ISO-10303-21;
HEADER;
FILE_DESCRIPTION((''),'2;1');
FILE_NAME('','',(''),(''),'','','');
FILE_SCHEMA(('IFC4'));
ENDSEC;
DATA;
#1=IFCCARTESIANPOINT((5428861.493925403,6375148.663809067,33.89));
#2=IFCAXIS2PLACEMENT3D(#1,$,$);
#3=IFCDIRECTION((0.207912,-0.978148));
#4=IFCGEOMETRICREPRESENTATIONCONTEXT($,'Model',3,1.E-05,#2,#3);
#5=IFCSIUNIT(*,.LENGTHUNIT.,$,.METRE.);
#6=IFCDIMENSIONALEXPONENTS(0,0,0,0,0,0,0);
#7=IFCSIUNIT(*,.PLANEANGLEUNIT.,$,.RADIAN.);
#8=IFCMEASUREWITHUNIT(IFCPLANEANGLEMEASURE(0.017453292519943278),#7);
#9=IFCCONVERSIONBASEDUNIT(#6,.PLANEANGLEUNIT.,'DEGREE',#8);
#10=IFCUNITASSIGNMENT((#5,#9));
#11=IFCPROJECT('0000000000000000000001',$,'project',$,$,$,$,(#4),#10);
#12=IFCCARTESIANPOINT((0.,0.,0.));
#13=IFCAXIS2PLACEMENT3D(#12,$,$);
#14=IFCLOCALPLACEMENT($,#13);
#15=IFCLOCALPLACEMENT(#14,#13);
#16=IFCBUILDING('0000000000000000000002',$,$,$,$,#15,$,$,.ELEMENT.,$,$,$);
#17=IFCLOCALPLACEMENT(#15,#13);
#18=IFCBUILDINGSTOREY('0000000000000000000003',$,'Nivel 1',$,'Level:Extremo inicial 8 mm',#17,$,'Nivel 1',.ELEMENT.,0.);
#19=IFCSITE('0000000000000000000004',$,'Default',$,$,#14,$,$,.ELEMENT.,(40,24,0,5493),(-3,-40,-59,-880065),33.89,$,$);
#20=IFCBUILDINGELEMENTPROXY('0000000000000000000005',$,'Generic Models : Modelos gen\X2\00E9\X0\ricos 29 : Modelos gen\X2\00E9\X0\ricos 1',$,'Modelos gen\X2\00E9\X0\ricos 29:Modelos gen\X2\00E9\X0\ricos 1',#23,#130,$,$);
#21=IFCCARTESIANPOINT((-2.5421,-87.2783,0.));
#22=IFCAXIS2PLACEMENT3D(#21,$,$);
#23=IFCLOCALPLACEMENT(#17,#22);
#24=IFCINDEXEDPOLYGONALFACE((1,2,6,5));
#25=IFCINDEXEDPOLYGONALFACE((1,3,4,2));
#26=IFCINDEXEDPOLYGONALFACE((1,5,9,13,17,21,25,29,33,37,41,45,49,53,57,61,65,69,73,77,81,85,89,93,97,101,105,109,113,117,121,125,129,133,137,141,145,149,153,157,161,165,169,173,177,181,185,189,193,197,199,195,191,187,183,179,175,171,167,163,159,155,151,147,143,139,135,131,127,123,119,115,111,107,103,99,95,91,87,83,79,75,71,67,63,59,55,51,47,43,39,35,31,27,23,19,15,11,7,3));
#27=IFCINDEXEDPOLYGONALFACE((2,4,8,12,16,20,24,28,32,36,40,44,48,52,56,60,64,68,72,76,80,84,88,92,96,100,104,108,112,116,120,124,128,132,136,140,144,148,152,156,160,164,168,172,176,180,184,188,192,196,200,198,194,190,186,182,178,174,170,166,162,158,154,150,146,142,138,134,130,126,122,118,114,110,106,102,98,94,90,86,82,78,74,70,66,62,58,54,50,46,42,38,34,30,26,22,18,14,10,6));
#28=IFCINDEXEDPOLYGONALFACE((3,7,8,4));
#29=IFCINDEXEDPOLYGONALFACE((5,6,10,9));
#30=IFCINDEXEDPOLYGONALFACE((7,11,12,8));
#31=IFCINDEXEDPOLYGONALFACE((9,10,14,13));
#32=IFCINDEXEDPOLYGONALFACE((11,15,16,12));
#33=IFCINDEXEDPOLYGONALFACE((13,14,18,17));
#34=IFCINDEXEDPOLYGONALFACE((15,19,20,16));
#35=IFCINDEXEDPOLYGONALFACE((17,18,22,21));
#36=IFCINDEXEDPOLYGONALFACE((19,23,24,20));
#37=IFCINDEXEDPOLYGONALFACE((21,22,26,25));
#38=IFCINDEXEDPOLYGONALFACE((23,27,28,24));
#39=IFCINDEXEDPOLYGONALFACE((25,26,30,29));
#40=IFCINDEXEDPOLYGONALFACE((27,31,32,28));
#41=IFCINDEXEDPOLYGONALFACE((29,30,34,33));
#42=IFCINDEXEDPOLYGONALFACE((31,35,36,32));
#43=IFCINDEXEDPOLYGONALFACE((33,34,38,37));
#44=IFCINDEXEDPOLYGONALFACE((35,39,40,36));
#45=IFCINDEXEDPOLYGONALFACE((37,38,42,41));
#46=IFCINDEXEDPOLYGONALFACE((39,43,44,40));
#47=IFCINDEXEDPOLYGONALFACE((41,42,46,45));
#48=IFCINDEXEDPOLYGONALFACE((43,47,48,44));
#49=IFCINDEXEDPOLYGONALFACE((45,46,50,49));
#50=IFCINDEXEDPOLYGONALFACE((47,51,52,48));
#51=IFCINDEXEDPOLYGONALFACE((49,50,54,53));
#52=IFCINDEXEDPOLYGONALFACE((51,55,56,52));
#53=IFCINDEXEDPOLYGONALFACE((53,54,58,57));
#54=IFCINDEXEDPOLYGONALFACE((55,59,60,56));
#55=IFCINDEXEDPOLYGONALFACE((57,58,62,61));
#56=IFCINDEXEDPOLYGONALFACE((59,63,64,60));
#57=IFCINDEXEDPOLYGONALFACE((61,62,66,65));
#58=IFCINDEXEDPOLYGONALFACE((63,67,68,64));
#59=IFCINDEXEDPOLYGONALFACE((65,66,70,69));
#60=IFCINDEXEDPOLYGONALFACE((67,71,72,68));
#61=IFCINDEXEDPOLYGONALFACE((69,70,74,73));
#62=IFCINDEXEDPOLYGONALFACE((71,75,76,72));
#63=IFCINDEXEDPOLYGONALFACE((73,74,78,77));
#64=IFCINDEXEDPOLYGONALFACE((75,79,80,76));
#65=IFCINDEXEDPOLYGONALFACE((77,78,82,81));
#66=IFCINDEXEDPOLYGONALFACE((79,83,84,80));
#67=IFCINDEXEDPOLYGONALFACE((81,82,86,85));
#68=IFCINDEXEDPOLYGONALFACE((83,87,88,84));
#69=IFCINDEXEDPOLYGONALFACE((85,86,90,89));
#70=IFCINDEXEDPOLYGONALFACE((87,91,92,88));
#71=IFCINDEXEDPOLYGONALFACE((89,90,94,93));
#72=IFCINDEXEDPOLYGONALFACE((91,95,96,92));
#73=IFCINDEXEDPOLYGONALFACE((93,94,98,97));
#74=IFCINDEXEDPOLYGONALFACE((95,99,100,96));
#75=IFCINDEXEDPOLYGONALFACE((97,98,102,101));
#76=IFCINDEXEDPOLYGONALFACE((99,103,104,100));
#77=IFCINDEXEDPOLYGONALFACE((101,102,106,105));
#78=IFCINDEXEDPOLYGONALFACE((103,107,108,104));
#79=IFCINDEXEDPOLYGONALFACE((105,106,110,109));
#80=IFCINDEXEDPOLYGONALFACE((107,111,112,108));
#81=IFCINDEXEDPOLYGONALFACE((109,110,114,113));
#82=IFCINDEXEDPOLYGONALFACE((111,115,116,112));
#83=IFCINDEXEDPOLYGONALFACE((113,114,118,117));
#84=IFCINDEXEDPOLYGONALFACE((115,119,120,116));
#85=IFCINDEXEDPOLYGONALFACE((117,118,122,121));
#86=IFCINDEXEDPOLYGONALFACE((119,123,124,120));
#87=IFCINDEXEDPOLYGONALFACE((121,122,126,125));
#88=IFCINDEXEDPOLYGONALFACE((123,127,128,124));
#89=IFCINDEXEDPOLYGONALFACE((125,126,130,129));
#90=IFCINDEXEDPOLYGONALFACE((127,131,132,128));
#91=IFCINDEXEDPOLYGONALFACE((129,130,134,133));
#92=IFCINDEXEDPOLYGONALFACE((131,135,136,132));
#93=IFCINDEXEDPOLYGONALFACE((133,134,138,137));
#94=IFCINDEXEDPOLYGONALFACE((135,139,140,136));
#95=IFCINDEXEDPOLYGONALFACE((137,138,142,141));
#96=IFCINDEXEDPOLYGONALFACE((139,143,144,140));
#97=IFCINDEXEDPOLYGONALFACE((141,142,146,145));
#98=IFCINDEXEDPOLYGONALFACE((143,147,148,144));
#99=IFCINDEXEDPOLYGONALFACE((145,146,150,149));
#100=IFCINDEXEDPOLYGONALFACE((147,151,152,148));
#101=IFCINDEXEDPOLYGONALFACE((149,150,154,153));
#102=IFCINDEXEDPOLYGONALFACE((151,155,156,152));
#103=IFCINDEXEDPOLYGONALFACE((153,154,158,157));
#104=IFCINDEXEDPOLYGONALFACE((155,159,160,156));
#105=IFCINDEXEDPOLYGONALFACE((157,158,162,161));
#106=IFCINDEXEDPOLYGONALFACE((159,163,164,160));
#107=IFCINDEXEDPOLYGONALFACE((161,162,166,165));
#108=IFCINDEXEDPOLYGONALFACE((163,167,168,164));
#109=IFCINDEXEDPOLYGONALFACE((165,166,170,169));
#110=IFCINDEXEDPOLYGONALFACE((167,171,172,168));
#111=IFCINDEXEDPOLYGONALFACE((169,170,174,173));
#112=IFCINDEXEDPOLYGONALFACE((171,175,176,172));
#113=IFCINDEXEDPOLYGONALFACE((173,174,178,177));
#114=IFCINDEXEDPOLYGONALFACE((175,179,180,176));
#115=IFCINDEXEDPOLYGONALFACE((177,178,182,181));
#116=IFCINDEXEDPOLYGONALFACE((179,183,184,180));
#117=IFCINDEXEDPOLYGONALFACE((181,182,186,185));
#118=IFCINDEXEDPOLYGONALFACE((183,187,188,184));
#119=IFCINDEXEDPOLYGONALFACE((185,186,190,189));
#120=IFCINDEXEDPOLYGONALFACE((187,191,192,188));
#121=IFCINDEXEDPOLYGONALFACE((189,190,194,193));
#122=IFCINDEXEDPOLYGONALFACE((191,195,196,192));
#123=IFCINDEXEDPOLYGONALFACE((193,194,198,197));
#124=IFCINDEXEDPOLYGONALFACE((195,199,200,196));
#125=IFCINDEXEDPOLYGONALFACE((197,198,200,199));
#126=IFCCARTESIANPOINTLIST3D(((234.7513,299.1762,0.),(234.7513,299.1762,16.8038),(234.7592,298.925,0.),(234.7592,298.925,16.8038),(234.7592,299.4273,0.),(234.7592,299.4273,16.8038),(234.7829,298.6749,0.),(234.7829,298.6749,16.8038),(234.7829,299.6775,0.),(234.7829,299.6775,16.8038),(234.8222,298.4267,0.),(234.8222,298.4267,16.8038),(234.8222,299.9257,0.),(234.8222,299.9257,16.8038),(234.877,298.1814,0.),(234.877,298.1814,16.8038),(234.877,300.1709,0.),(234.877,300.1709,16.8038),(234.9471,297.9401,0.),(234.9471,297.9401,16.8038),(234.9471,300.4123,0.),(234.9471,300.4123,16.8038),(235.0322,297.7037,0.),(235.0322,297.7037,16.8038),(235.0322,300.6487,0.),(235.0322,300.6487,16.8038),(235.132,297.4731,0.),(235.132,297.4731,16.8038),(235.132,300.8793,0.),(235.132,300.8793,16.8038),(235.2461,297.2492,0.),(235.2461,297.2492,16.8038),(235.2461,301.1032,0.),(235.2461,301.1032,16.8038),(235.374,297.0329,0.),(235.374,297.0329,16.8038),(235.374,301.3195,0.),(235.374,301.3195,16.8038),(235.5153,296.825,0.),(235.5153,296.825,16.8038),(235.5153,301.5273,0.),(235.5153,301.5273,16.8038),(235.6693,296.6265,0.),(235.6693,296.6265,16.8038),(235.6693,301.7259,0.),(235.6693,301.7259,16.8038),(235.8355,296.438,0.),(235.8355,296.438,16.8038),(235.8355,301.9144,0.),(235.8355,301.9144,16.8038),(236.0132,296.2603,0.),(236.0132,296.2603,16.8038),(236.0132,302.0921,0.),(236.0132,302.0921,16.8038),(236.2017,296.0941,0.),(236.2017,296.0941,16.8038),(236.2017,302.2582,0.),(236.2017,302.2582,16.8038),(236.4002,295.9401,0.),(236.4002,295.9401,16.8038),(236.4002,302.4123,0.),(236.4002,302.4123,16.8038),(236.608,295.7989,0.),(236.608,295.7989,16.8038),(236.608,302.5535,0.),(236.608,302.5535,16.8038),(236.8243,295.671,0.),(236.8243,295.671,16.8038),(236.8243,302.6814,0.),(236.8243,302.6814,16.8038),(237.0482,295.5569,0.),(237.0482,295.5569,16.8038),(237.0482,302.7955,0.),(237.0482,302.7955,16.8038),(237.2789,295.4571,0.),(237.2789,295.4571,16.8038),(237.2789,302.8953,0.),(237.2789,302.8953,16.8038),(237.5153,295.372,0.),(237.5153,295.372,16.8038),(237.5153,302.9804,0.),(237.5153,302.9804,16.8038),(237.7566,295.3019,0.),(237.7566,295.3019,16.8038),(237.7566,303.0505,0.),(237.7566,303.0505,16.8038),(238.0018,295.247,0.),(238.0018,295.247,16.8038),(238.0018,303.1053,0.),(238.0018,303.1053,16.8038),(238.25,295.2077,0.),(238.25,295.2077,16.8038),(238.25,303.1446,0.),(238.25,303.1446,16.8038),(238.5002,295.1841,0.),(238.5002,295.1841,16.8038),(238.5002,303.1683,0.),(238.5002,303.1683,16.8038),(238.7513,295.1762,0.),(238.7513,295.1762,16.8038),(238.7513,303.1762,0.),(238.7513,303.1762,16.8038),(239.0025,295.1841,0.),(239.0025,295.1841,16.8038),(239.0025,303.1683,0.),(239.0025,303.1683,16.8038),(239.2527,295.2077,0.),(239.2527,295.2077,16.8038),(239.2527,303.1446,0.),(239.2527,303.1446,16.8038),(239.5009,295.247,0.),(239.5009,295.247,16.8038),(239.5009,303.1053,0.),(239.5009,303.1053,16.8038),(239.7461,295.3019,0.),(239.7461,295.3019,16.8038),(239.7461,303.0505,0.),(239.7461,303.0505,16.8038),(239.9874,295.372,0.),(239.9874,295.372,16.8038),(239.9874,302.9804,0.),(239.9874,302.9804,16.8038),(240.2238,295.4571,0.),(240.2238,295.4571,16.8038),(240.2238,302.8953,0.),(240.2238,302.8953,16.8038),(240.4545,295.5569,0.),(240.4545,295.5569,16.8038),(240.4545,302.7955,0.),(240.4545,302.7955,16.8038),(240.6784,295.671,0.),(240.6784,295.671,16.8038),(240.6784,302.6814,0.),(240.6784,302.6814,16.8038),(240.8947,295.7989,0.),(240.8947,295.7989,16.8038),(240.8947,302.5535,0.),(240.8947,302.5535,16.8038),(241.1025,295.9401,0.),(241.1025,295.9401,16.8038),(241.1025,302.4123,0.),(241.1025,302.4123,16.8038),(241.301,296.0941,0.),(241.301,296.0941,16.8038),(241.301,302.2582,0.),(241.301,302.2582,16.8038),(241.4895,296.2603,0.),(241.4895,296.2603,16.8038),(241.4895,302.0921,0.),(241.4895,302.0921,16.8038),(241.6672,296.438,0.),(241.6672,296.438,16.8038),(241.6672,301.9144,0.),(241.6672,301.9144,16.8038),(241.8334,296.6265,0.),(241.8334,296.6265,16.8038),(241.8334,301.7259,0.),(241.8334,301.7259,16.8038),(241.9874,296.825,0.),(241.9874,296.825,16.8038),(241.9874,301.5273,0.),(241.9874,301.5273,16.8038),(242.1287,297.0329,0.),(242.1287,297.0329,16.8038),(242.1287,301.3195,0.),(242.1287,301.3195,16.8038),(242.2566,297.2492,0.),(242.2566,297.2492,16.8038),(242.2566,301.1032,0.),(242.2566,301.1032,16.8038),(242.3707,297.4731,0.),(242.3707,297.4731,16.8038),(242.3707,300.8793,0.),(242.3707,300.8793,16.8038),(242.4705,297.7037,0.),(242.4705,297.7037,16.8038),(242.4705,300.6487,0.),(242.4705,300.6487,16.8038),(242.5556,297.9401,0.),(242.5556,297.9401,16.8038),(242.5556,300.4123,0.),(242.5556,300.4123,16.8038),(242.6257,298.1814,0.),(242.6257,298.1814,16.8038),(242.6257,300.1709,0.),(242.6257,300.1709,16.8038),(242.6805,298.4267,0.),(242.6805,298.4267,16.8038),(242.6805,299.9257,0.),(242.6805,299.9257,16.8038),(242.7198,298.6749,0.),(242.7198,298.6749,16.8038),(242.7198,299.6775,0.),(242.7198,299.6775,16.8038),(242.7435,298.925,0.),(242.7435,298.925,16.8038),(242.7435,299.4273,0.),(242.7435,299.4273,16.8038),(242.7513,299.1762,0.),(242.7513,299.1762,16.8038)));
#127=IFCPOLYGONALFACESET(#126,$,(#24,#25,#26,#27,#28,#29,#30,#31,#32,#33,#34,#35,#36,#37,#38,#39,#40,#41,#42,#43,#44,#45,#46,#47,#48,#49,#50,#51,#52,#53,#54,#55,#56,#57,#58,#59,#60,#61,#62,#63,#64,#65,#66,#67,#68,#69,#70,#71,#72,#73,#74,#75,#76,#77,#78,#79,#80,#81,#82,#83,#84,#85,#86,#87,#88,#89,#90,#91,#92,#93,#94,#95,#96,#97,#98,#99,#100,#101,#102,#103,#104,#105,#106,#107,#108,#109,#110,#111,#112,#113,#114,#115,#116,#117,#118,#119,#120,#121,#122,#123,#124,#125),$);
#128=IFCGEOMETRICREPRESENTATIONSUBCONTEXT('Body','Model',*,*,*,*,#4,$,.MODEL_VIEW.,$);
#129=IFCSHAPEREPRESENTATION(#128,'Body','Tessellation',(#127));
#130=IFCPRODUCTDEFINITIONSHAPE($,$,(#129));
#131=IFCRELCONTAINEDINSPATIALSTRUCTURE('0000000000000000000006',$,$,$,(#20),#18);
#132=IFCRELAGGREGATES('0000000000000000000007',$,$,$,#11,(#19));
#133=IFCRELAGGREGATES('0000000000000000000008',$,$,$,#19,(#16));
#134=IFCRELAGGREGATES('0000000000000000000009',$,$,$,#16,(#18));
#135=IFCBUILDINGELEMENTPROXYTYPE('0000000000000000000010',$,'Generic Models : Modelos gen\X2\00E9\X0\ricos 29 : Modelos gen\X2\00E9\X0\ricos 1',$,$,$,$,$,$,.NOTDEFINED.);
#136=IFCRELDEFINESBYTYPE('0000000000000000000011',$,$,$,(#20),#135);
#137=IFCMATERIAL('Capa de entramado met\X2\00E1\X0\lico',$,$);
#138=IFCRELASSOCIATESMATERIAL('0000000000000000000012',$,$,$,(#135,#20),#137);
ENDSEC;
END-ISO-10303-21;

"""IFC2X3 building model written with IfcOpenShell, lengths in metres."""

from ifc_helpers import new_model, entity, si_unit, converted_unit, direction, frame, origin, origin_2d_with_axis, place, context, subcontext, project, spatial, circle, extrude, source, transform, mapped, material, type_object, type_shapes, element, save


model = new_model("IFC2X3")

# Units and contexts
model_context = context("Model", 3, precision=1e-05, world=frame((5428861.493925403, 6375148.663809067, 33.89)), true_north=direction((0.207912, -0.978148)))
body_context = subcontext(model_context, "Body", "Model", "MODEL_VIEW")
ifc_project = project(units=[si_unit("LENGTHUNIT", "METRE"), converted_unit("PLANEANGLEUNIT", "DEGREE", entity("IfcPlaneAngleMeasure", 0.017453292519943278), si_unit("PLANEANGLEUNIT", "RADIAN"), dimensions=[0, 0, 0, 0, 0, 0, 0])], contexts=[model_context])

# Site, building, storey
site_placement = place(None, origin())
site = spatial("IfcSite", under=ifc_project, at=site_placement, Name="Default", CompositionType="ELEMENT", RefLatitude=(40, 24, 0, 5493), RefLongitude=(-3, -40, -59, -880065), RefElevation=33.89)
building_placement = place(site_placement, origin())
building = spatial("IfcBuilding", under=site, at=building_placement, CompositionType="ELEMENT")
storey_placement = place(building_placement, origin())
storey = spatial("IfcBuildingStorey", under=building, at=storey_placement, Name="Nivel 1", ObjectType="Level:Extremo inicial 8 mm", LongName="Nivel 1", CompositionType="ELEMENT", Elevation=0.0)

# Building element proxy
ifc_material_1 = material(Name="Capa de entramado metálico")
building_element_proxy_type_1 = type_object("IfcBuildingElementProxyType", Name="Generic Models : Modelos genéricos 29 : Modelos genéricos 1", PredefinedType="NOTDEFINED", material=ifc_material_1)
shared_shape_1 = source(origin(), body_context, "Body", "SweptSolid", [
    extrude(circle(Radius=4.0, at=origin_2d_with_axis()), frame((238.7513, 299.1762, 0.0)), (0.0, 0.0, 1.0), 16.8038),
])
type_shapes(building_element_proxy_type_1, [shared_shape_1])
proxy_1_placement = place(storey_placement, frame((-2.5421, -87.2783, 0.0)))
element("IfcBuildingElementProxy", 1, at=proxy_1_placement, inside=storey, type_object=building_element_proxy_type_1, material=ifc_material_1, Name="Generic Models : Modelos genéricos 29 : Modelos genéricos 1", ObjectType="Modelos genéricos 29:Modelos genéricos 1", context=body_context, shape_type="MappedRepresentation", body=[
    mapped(shared_shape_1, transform((0.0, 0.0, 0.0), scale=1.0)),
])

save(model, "model.ifc")
